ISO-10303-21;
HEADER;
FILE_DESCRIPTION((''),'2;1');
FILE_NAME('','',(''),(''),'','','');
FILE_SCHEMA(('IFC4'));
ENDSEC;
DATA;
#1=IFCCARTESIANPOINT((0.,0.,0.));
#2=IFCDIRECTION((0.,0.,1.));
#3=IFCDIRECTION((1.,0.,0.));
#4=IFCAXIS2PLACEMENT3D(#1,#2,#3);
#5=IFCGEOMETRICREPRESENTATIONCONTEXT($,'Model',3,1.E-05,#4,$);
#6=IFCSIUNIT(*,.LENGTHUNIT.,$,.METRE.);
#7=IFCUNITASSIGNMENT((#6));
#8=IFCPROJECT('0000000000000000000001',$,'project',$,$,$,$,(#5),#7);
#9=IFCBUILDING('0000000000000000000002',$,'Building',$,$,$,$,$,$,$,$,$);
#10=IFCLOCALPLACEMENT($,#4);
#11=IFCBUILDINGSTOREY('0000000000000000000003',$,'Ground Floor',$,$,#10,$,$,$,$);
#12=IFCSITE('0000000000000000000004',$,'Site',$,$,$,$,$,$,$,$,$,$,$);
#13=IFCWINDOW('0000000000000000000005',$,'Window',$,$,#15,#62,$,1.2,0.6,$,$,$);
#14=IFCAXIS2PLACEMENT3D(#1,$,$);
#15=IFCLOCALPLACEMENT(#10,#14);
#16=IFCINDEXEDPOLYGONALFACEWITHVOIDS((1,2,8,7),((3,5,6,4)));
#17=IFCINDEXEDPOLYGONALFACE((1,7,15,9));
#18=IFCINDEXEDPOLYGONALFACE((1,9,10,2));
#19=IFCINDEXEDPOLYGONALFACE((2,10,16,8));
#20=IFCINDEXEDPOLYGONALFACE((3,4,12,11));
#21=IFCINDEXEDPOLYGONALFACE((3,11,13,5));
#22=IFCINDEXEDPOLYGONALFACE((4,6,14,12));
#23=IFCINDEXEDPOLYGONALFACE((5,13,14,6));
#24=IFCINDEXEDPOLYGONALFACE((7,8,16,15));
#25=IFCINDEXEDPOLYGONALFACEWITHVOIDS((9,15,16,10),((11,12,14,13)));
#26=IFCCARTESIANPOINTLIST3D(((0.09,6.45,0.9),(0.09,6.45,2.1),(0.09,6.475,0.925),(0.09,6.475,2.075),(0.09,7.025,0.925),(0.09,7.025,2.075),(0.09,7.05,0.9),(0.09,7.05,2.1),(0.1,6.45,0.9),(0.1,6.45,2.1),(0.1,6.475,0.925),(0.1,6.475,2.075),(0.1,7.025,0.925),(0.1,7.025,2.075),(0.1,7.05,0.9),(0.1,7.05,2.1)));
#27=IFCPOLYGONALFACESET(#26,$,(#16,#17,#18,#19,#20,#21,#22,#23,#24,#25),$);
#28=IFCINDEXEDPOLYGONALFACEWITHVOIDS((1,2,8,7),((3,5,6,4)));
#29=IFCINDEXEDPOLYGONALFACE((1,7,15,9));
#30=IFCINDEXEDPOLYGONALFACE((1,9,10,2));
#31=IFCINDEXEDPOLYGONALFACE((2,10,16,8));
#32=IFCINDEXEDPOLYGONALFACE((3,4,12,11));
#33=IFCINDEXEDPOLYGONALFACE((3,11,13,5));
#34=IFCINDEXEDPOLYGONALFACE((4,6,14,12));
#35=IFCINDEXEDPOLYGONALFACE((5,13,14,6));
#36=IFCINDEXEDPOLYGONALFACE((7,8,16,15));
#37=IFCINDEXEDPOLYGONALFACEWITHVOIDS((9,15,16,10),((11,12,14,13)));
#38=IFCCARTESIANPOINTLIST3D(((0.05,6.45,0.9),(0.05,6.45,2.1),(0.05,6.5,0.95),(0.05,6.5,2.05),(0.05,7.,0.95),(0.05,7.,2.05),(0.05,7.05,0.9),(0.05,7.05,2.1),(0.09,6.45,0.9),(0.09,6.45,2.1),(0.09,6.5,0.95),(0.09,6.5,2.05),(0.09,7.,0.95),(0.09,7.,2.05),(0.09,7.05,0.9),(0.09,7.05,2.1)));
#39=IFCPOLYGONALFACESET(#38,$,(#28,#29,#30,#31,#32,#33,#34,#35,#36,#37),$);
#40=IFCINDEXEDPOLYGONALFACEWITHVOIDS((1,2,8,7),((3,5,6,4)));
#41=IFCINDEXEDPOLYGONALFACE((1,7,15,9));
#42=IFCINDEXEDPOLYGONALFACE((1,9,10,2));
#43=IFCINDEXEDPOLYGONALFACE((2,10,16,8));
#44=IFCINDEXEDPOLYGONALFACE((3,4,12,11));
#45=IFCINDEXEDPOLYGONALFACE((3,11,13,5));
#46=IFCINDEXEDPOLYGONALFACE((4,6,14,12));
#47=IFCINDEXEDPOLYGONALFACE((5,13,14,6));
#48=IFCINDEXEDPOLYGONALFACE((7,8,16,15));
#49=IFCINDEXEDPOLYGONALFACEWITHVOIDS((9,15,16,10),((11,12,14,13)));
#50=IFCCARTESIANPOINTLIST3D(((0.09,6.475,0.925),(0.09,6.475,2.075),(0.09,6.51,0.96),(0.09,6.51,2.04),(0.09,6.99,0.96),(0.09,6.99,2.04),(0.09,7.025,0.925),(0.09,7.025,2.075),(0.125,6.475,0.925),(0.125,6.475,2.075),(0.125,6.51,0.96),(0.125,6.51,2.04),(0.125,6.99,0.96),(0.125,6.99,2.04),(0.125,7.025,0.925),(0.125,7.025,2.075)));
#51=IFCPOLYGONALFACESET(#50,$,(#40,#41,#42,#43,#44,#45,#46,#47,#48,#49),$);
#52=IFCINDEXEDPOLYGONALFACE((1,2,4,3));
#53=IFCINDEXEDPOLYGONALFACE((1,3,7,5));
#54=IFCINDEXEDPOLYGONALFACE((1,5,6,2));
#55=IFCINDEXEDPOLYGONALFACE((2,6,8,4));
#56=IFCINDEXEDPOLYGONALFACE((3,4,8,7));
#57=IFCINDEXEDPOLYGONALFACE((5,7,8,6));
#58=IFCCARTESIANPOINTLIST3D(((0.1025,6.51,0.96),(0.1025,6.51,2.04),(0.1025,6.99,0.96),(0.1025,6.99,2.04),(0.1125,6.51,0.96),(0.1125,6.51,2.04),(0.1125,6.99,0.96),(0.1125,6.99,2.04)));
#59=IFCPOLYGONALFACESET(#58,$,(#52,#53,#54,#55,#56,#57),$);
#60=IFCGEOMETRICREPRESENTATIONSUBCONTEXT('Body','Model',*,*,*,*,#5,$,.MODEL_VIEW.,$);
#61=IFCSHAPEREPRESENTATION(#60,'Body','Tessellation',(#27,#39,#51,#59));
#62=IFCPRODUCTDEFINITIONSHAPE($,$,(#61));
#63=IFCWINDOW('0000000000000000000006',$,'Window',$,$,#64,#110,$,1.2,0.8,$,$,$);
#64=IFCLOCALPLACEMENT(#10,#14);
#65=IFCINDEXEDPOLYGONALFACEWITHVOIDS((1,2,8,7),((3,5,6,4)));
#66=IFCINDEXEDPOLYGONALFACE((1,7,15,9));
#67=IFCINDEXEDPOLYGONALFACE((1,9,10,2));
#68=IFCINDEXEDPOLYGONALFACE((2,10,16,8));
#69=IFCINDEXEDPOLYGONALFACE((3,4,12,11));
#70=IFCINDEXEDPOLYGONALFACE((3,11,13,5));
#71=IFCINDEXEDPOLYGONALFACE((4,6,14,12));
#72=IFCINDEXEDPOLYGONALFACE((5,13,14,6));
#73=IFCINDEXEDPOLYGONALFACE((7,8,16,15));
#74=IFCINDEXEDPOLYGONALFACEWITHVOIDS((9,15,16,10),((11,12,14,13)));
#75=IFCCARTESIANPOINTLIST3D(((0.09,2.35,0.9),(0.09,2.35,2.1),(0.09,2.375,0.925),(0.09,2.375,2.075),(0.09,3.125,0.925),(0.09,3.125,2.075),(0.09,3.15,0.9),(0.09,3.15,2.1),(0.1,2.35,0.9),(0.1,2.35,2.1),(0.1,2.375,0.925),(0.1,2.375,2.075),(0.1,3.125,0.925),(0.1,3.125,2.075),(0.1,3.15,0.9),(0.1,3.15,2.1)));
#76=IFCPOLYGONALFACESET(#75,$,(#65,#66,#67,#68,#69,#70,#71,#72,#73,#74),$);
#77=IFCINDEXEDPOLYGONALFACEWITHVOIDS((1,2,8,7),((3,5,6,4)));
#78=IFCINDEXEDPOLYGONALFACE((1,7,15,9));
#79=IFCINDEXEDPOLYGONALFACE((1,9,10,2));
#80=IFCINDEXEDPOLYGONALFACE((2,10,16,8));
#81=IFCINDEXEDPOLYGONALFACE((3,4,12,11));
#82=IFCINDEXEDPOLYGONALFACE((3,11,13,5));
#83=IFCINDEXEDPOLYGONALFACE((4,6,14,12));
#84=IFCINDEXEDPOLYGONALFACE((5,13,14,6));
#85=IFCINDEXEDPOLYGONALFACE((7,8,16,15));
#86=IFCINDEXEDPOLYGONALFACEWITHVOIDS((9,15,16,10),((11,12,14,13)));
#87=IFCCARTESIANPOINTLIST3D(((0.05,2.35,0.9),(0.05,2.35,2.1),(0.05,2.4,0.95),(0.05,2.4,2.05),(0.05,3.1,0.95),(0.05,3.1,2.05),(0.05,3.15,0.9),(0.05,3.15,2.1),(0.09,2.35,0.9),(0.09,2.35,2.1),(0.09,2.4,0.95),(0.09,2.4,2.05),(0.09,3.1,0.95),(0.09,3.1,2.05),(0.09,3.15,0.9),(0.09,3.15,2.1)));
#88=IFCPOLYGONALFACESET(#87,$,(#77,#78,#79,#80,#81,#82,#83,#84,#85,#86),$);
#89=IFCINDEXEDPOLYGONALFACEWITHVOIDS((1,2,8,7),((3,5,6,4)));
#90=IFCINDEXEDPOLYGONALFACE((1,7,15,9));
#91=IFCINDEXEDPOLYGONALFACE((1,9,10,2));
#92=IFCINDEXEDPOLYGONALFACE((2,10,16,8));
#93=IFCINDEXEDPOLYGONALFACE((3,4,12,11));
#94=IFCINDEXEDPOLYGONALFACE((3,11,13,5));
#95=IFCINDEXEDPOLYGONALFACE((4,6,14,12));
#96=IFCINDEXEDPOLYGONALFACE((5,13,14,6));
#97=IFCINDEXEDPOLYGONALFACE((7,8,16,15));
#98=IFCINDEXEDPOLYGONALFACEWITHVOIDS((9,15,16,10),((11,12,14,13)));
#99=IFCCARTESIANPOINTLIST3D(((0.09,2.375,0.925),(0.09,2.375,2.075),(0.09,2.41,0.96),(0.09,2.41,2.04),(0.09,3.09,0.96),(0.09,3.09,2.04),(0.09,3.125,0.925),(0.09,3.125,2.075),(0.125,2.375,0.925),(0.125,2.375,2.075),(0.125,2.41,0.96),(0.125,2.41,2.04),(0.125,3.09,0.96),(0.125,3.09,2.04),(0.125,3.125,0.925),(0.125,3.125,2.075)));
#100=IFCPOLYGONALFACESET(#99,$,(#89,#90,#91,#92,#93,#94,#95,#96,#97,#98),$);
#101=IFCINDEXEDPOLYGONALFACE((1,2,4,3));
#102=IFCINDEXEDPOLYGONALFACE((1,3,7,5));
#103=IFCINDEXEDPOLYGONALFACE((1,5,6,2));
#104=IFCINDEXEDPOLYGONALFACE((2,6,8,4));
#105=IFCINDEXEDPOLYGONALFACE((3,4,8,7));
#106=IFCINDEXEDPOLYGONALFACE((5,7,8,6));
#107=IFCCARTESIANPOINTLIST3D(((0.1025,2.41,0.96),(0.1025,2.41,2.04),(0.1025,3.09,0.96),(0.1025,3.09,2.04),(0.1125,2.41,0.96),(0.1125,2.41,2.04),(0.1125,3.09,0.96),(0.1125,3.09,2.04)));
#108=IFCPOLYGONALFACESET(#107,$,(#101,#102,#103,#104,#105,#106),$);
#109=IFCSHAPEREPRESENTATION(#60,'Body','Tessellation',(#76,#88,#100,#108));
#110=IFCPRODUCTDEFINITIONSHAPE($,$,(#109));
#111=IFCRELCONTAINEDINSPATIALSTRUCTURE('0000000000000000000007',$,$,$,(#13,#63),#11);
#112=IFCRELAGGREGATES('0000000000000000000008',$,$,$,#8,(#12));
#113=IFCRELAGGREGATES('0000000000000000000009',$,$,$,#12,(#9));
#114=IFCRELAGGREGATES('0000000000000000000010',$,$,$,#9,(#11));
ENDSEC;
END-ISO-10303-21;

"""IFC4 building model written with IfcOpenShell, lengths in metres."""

from ifc_helpers import new_model, si_unit, frame, origin_with_axes, place, context, subcontext, project, spatial, line, indexed_curve, outline, extrude, element, save


model = new_model("IFC4")

# Units and contexts
model_context = context("Model", 3, precision=1e-05, world=origin_with_axes())
body_context = subcontext(model_context, "Body", "Model", "MODEL_VIEW")
ifc_project = project(units=[si_unit("LENGTHUNIT", "METRE")], contexts=[model_context])

# Site, building, storey
site = spatial("IfcSite", under=ifc_project, Name="Site")
building = spatial("IfcBuilding", under=site, Name="Building")
storey_placement = place(None, origin_with_axes())
storey = spatial("IfcBuildingStorey", under=building, at=storey_placement, Name="Ground Floor")

# Windows
window_1_placement = place(storey_placement, frame((0.0, 7.05, 0.9), z_axis=(0.0, 0.0, 1.0), x_axis=(0.0, -1.0, 0.0)))
element("IfcWindow", 1, at=window_1_placement, inside=storey, Name="Window", OverallHeight=1.2, OverallWidth=0.6, context=body_context, shape_type="SweptSolid", body=[
    extrude(outline(indexed_curve([(0.0, 0.0), (0.6, 0.0), (0.6, 1.2), (0.0, 1.2)], segments=[line(1, 2, 3, 4, 1)]), holes=[indexed_curve([(0.025, 0.025), (0.575, 0.025), (0.575, 1.175), (0.025, 1.175)], segments=[line(1, 2, 3, 4, 1)])]), frame((0.0, 0.09, 0.0), z_axis=(0.0, -1.0, 0.0), x_axis=(1.0, 0.0, 0.0)), (0.0, 0.0, -1.0), 0.01),
    extrude(outline(indexed_curve([(0.0, 0.0), (0.6, 0.0), (0.6, 1.2), (0.0, 1.2)], segments=[line(1, 2, 3, 4, 1)]), holes=[indexed_curve([(0.05, 0.05), (0.55, 0.05), (0.55, 1.15), (0.05, 1.15)], segments=[line(1, 2, 3, 4, 1)])]), frame((0.0, 0.05, 0.0), z_axis=(0.0, -1.0, 0.0), x_axis=(1.0, 0.0, 0.0)), (0.0, 0.0, -1.0), 0.04),
    extrude(outline(indexed_curve([(0.0, 0.0), (0.55, 0.0), (0.55, 1.15), (0.0, 1.15)], segments=[line(1, 2, 3, 4, 1)]), holes=[indexed_curve([(0.035, 0.035), (0.515, 0.035), (0.515, 1.115), (0.035, 1.115)], segments=[line(1, 2, 3, 4, 1)])]), frame((0.025, 0.09, 0.025), z_axis=(0.0, -1.0, 0.0), x_axis=(1.0, 0.0, 0.0)), (0.0, 0.0, -1.0), 0.035),
    extrude(outline(indexed_curve([(0.035, 0.035), (0.515, 0.035), (0.515, 1.115), (0.035, 1.115)], segments=[line(1, 2, 3, 4, 1)])), frame((0.025, 0.1025, 0.025), z_axis=(0.0, -1.0, 0.0), x_axis=(1.0, 0.0, 0.0)), (0.0, 0.0, -1.0), 0.01),
])
window_2_placement = place(storey_placement, frame((0.0, 3.15, 0.9), z_axis=(0.0, 0.0, 1.0), x_axis=(0.0, -1.0, 0.0)))
element("IfcWindow", 2, at=window_2_placement, inside=storey, Name="Window", OverallHeight=1.2, OverallWidth=0.8, context=body_context, shape_type="SweptSolid", body=[
    extrude(outline(indexed_curve([(0.0, 0.0), (0.8, 0.0), (0.8, 1.2), (0.0, 1.2)], segments=[line(1, 2, 3, 4, 1)]), holes=[indexed_curve([(0.025, 0.025), (0.775, 0.025), (0.775, 1.175), (0.025, 1.175)], segments=[line(1, 2, 3, 4, 1)])]), frame((0.0, 0.09, 0.0), z_axis=(0.0, -1.0, 0.0), x_axis=(1.0, 0.0, 0.0)), (0.0, 0.0, -1.0), 0.01),
    extrude(outline(indexed_curve([(0.0, 0.0), (0.8, 0.0), (0.8, 1.2), (0.0, 1.2)], segments=[line(1, 2, 3, 4, 1)]), holes=[indexed_curve([(0.05, 0.05), (0.75, 0.05), (0.75, 1.15), (0.05, 1.15)], segments=[line(1, 2, 3, 4, 1)])]), frame((0.0, 0.05, 0.0), z_axis=(0.0, -1.0, 0.0), x_axis=(1.0, 0.0, 0.0)), (0.0, 0.0, -1.0), 0.04),
    extrude(outline(indexed_curve([(0.0, 0.0), (0.75, 0.0), (0.75, 1.15), (0.0, 1.15)], segments=[line(1, 2, 3, 4, 1)]), holes=[indexed_curve([(0.035, 0.035), (0.715, 0.035), (0.715, 1.115), (0.035, 1.115)], segments=[line(1, 2, 3, 4, 1)])]), frame((0.025, 0.09, 0.025), z_axis=(0.0, -1.0, 0.0), x_axis=(1.0, 0.0, 0.0)), (0.0, 0.0, -1.0), 0.035),
    extrude(outline(indexed_curve([(0.035, 0.035), (0.715, 0.035), (0.715, 1.115), (0.035, 1.115)], segments=[line(1, 2, 3, 4, 1)])), frame((0.025, 0.1025, 0.025), z_axis=(0.0, -1.0, 0.0), x_axis=(1.0, 0.0, 0.0)), (0.0, 0.0, -1.0), 0.01),
])

save(model, "model.ifc")
